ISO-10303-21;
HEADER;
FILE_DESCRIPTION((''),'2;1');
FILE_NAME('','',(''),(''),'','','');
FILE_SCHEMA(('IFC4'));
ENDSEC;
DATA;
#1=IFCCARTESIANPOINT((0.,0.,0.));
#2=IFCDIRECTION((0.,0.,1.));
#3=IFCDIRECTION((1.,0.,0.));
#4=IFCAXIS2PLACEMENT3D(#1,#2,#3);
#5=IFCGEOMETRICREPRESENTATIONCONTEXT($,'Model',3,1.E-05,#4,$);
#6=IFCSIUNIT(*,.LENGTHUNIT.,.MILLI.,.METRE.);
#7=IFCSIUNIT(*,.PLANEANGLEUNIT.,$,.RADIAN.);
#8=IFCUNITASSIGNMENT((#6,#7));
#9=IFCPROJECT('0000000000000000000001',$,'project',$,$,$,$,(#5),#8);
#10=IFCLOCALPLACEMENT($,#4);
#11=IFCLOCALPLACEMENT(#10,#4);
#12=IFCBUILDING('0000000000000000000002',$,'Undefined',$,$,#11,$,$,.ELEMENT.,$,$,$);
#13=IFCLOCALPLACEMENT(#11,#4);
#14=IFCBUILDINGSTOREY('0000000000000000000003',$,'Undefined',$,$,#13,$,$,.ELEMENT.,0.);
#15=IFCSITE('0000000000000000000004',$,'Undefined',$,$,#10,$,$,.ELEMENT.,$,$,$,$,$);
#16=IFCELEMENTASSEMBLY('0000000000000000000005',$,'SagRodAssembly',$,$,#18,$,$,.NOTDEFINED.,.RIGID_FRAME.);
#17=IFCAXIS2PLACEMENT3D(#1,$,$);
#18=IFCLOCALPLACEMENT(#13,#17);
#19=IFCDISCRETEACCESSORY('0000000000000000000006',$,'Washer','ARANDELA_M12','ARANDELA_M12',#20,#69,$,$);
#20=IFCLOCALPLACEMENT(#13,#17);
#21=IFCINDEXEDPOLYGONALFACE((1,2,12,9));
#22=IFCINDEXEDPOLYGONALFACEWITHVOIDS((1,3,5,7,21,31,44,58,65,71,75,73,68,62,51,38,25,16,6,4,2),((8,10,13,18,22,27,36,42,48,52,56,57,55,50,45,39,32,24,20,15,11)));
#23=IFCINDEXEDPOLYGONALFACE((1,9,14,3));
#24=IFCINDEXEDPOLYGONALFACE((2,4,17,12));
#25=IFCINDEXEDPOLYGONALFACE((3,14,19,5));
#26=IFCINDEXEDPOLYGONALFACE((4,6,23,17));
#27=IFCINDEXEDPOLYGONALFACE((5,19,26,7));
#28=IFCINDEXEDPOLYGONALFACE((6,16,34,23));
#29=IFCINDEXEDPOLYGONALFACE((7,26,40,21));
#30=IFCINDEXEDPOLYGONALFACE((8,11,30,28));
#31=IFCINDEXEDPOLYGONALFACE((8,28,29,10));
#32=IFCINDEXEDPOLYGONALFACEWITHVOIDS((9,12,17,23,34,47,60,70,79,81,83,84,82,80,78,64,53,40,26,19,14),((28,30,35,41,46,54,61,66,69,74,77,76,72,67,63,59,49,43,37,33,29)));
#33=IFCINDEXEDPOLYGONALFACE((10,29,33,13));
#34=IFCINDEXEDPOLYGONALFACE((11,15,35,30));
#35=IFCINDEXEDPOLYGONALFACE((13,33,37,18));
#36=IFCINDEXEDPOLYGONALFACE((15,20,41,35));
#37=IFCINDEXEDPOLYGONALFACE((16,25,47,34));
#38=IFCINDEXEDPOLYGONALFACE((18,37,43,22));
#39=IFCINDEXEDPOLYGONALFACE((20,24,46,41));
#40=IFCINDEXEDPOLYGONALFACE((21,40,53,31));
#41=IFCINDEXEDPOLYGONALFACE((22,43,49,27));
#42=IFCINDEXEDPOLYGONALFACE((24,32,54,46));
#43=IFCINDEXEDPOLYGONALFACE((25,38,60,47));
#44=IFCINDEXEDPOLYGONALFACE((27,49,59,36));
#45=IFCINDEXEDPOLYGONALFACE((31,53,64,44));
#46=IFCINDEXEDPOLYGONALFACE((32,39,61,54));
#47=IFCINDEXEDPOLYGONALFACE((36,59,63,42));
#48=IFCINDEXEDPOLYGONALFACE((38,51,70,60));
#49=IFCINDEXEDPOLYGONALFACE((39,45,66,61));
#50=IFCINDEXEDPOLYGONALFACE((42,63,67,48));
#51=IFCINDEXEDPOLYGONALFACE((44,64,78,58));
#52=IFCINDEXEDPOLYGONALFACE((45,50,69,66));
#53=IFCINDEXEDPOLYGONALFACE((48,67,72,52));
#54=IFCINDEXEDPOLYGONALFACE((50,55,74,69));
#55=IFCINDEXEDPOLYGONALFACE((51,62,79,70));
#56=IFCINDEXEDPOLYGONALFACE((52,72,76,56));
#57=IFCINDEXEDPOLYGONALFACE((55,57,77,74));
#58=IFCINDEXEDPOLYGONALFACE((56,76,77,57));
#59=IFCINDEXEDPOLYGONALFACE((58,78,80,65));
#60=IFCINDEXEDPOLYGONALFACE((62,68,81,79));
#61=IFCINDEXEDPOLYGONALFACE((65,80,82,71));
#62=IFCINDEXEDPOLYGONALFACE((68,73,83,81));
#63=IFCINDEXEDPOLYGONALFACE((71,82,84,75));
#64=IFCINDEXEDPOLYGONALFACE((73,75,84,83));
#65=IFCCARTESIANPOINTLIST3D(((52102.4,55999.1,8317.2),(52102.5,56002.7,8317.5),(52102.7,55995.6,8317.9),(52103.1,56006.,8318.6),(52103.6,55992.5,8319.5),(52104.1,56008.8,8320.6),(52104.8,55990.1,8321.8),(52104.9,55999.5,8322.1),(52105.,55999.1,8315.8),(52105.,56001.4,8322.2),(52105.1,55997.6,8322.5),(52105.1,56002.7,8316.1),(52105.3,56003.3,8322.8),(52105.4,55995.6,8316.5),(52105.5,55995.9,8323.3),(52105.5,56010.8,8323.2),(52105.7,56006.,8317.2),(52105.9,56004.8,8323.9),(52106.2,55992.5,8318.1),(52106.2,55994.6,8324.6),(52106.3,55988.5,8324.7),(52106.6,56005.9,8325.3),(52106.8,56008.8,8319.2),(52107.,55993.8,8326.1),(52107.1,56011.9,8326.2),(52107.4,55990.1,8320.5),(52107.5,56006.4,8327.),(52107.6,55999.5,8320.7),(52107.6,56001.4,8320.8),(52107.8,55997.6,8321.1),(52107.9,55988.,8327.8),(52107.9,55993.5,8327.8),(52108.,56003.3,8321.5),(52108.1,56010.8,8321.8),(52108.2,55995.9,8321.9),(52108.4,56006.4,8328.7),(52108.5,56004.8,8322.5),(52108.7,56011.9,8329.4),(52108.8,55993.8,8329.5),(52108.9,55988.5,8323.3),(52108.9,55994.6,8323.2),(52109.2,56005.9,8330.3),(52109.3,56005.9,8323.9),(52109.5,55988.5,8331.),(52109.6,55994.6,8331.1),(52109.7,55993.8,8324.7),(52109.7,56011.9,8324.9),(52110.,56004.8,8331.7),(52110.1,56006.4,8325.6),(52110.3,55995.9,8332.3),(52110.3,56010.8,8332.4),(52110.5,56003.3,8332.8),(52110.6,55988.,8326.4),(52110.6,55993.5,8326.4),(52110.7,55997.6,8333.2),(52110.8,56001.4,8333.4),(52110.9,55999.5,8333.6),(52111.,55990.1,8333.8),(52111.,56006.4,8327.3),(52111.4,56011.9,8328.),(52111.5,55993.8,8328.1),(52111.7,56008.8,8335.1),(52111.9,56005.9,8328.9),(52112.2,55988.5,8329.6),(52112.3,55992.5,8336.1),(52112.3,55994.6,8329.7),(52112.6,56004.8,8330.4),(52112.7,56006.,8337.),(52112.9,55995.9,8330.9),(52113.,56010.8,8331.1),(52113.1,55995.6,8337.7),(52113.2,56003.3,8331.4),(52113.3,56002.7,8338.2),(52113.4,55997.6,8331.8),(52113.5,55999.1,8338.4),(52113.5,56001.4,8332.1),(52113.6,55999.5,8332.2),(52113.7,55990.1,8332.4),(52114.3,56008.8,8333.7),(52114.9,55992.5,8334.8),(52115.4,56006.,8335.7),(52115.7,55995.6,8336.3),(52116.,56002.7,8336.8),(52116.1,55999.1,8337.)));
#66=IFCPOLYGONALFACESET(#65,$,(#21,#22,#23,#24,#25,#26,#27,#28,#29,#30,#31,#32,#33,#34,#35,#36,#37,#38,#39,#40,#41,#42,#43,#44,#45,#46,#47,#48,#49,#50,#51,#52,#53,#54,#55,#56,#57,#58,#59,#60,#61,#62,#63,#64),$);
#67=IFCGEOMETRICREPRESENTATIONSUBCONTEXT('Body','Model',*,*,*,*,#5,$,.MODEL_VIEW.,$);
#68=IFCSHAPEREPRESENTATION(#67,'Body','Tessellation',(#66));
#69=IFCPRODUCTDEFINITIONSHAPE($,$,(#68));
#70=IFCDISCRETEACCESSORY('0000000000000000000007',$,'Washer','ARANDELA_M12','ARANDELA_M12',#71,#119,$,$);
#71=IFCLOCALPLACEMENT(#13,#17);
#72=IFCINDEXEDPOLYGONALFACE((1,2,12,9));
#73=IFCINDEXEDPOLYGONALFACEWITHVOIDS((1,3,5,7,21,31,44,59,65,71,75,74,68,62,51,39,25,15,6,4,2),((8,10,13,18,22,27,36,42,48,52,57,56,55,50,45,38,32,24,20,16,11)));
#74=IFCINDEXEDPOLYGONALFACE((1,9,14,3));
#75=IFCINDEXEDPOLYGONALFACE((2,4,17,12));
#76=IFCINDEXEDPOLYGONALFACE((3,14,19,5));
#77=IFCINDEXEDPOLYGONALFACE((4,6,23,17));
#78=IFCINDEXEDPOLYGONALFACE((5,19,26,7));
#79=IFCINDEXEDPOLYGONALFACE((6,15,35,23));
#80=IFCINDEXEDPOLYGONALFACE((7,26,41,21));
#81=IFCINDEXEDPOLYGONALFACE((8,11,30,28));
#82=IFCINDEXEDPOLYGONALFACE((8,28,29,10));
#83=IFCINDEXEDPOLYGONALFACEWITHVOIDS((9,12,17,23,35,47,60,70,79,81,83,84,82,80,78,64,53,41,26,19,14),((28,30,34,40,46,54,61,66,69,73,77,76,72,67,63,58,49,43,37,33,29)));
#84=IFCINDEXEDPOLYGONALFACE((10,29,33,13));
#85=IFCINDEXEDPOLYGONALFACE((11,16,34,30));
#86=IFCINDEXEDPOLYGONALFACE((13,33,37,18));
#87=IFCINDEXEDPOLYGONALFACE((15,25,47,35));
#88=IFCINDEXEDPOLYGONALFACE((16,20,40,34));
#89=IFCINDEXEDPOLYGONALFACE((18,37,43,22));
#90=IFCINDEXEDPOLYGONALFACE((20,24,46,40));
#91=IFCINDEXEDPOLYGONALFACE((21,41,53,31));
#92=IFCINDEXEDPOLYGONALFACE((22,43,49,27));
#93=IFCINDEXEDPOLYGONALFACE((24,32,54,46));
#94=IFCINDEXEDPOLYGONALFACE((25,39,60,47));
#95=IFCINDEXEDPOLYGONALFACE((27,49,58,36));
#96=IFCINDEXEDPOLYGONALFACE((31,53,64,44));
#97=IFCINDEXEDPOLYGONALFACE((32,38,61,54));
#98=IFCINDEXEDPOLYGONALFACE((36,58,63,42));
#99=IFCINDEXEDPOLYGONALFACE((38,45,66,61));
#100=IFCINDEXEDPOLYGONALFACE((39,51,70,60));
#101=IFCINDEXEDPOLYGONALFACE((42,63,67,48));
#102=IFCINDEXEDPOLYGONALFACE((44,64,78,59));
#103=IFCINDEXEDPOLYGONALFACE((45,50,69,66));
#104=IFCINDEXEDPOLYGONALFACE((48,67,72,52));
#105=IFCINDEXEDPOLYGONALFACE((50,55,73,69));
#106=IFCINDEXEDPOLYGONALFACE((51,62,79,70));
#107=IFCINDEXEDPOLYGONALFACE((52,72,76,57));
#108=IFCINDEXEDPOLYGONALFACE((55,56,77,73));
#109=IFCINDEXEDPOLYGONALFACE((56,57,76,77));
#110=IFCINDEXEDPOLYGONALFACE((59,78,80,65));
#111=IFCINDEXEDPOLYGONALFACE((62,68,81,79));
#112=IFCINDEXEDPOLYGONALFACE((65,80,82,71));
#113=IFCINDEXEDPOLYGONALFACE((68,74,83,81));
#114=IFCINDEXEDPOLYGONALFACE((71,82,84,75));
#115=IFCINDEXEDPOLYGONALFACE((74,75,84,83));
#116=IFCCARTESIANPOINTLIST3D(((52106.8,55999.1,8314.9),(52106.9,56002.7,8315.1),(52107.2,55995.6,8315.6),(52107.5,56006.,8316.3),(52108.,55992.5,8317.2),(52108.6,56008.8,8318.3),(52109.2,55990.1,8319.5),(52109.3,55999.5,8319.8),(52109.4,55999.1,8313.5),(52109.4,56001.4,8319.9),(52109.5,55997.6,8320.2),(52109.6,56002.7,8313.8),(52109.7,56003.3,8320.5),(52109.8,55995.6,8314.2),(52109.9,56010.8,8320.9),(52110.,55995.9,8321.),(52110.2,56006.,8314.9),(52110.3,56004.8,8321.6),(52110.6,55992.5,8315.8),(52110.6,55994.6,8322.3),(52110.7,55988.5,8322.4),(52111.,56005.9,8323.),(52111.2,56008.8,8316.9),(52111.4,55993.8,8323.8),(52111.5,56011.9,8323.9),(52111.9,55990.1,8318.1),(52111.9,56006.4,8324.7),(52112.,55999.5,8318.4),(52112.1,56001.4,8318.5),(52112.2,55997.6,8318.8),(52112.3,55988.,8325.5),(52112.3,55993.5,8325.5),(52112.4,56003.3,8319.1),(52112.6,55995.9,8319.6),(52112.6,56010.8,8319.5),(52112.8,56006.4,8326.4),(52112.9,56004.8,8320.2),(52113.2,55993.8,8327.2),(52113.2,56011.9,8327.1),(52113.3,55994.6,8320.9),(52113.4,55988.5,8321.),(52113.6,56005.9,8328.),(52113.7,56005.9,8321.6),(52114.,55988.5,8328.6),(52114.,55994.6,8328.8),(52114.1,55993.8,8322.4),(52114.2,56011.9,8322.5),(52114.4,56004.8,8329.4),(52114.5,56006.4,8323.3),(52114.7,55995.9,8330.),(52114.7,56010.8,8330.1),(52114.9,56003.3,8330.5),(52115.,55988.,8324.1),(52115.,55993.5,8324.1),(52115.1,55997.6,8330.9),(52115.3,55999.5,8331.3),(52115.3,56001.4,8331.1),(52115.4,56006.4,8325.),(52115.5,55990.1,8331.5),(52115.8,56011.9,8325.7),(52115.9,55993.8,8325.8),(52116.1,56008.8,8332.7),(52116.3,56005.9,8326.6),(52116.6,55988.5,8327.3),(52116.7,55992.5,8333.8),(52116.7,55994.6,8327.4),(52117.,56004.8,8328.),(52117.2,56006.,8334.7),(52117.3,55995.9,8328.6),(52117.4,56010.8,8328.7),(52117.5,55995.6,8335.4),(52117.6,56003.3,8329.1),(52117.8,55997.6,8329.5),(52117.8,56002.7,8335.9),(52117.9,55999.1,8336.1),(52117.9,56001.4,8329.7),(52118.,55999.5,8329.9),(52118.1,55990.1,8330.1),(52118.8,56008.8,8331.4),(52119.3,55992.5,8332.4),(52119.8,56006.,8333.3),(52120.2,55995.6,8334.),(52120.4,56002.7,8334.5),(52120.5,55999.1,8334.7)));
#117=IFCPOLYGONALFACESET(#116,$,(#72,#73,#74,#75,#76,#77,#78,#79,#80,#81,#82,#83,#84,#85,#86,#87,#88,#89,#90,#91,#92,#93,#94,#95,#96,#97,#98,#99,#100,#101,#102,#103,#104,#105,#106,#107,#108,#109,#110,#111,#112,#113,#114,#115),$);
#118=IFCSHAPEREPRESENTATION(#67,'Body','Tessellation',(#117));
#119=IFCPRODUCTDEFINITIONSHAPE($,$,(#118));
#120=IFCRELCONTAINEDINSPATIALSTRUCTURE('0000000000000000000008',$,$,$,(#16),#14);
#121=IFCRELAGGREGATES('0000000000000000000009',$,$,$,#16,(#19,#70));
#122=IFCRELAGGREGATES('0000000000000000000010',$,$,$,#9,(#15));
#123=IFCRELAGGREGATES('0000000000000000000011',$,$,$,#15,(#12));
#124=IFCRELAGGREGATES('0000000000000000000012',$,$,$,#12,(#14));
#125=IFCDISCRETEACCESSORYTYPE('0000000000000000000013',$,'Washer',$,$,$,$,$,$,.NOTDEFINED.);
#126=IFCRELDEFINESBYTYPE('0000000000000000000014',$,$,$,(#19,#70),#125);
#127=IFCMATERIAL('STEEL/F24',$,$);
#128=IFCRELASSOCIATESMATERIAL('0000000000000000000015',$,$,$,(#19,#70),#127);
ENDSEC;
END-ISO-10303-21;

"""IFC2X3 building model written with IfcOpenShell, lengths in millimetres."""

from ifc_helpers import new_model, si_unit, frame, origin_with_axes, origin_2d_with_axis, place, context, subcontext, project, spatial, hollow_circle, extrude, material, type_object, element, aggregate, save


model = new_model("IFC2X3")

# Units and contexts
model_context = context("Model", 3, precision=1e-05, world=origin_with_axes())
body_context = subcontext(model_context, "Body", "Model", "MODEL_VIEW")
ifc_project = project(units=[si_unit("LENGTHUNIT", "METRE", prefix="MILLI"), si_unit("PLANEANGLEUNIT", "RADIAN")], contexts=[model_context])

# Site, building, storey
site_placement = place(None, origin_with_axes())
site = spatial("IfcSite", under=ifc_project, at=site_placement, Name="Undefined", CompositionType="ELEMENT")
building_placement = place(site_placement, origin_with_axes())
building = spatial("IfcBuilding", under=site, at=building_placement, Name="Undefined", CompositionType="ELEMENT")
storey_placement = place(building_placement, origin_with_axes())
storey = spatial("IfcBuildingStorey", under=building, at=storey_placement, Name="Undefined", CompositionType="ELEMENT", Elevation=0.0)

# Shared definitions
ifc_material_1 = material(Name="STEEL/F24")

# Element assembly
assembly_1_placement = place(storey_placement, origin_with_axes())
assembly_1 = element("IfcElementAssembly", 1, at=assembly_1_placement, inside=storey, Name="SagRodAssembly", AssemblyPlace="NOTDEFINED", PredefinedType="RIGID_FRAME")

# Discrete accessories
discrete_accessory_type_1 = type_object("IfcDiscreteAccessoryType", Name="Washer")
discrete_accessory_1_placement = place(assembly_1_placement, frame((52110.6, 56000.0, 8326.4), z_axis=(-0.463578, 0.0, -0.886056), x_axis=(-0.886056, 0.0, 0.463578)))
discrete_accessory_1 = element("IfcDiscreteAccessory", 2, at=discrete_accessory_1_placement, type_object=discrete_accessory_type_1, material=ifc_material_1, Name="Washer", Description="ARANDELA_M12", ObjectType="ARANDELA_M12", context=body_context, shape_type="SweptSolid", body=[
    extrude(hollow_circle(Radius=12.0, WallThickness=5.5, at=origin_2d_with_axis()), frame((3.0, 0.0, 0.0), z_axis=(-1.0, 0.0, 0.0), x_axis=(0.0, -1.0, 0.0)), (0.0, 0.0, 1.0), 3.0),
])
discrete_accessory_2_placement = place(assembly_1_placement, frame((52115.0, 56000.0, 8324.1), z_axis=(-0.463578, 0.0, -0.886056), x_axis=(-0.886056, 0.0, 0.463578)))
discrete_accessory_2 = element("IfcDiscreteAccessory", 3, at=discrete_accessory_2_placement, type_object=discrete_accessory_type_1, material=ifc_material_1, Name="Washer", Description="ARANDELA_M12", ObjectType="ARANDELA_M12", context=body_context, shape_type="SweptSolid", body=[
    extrude(hollow_circle(Radius=12.0, WallThickness=5.5, at=origin_2d_with_axis()), frame((3.0, 0.0, 0.0), z_axis=(-1.0, 0.0, 0.0), x_axis=(0.0, -1.0, 0.0)), (0.0, 0.0, 1.0), 3.0),
])
aggregate(assembly_1, [discrete_accessory_1, discrete_accessory_2])

save(model, "model.ifc")
